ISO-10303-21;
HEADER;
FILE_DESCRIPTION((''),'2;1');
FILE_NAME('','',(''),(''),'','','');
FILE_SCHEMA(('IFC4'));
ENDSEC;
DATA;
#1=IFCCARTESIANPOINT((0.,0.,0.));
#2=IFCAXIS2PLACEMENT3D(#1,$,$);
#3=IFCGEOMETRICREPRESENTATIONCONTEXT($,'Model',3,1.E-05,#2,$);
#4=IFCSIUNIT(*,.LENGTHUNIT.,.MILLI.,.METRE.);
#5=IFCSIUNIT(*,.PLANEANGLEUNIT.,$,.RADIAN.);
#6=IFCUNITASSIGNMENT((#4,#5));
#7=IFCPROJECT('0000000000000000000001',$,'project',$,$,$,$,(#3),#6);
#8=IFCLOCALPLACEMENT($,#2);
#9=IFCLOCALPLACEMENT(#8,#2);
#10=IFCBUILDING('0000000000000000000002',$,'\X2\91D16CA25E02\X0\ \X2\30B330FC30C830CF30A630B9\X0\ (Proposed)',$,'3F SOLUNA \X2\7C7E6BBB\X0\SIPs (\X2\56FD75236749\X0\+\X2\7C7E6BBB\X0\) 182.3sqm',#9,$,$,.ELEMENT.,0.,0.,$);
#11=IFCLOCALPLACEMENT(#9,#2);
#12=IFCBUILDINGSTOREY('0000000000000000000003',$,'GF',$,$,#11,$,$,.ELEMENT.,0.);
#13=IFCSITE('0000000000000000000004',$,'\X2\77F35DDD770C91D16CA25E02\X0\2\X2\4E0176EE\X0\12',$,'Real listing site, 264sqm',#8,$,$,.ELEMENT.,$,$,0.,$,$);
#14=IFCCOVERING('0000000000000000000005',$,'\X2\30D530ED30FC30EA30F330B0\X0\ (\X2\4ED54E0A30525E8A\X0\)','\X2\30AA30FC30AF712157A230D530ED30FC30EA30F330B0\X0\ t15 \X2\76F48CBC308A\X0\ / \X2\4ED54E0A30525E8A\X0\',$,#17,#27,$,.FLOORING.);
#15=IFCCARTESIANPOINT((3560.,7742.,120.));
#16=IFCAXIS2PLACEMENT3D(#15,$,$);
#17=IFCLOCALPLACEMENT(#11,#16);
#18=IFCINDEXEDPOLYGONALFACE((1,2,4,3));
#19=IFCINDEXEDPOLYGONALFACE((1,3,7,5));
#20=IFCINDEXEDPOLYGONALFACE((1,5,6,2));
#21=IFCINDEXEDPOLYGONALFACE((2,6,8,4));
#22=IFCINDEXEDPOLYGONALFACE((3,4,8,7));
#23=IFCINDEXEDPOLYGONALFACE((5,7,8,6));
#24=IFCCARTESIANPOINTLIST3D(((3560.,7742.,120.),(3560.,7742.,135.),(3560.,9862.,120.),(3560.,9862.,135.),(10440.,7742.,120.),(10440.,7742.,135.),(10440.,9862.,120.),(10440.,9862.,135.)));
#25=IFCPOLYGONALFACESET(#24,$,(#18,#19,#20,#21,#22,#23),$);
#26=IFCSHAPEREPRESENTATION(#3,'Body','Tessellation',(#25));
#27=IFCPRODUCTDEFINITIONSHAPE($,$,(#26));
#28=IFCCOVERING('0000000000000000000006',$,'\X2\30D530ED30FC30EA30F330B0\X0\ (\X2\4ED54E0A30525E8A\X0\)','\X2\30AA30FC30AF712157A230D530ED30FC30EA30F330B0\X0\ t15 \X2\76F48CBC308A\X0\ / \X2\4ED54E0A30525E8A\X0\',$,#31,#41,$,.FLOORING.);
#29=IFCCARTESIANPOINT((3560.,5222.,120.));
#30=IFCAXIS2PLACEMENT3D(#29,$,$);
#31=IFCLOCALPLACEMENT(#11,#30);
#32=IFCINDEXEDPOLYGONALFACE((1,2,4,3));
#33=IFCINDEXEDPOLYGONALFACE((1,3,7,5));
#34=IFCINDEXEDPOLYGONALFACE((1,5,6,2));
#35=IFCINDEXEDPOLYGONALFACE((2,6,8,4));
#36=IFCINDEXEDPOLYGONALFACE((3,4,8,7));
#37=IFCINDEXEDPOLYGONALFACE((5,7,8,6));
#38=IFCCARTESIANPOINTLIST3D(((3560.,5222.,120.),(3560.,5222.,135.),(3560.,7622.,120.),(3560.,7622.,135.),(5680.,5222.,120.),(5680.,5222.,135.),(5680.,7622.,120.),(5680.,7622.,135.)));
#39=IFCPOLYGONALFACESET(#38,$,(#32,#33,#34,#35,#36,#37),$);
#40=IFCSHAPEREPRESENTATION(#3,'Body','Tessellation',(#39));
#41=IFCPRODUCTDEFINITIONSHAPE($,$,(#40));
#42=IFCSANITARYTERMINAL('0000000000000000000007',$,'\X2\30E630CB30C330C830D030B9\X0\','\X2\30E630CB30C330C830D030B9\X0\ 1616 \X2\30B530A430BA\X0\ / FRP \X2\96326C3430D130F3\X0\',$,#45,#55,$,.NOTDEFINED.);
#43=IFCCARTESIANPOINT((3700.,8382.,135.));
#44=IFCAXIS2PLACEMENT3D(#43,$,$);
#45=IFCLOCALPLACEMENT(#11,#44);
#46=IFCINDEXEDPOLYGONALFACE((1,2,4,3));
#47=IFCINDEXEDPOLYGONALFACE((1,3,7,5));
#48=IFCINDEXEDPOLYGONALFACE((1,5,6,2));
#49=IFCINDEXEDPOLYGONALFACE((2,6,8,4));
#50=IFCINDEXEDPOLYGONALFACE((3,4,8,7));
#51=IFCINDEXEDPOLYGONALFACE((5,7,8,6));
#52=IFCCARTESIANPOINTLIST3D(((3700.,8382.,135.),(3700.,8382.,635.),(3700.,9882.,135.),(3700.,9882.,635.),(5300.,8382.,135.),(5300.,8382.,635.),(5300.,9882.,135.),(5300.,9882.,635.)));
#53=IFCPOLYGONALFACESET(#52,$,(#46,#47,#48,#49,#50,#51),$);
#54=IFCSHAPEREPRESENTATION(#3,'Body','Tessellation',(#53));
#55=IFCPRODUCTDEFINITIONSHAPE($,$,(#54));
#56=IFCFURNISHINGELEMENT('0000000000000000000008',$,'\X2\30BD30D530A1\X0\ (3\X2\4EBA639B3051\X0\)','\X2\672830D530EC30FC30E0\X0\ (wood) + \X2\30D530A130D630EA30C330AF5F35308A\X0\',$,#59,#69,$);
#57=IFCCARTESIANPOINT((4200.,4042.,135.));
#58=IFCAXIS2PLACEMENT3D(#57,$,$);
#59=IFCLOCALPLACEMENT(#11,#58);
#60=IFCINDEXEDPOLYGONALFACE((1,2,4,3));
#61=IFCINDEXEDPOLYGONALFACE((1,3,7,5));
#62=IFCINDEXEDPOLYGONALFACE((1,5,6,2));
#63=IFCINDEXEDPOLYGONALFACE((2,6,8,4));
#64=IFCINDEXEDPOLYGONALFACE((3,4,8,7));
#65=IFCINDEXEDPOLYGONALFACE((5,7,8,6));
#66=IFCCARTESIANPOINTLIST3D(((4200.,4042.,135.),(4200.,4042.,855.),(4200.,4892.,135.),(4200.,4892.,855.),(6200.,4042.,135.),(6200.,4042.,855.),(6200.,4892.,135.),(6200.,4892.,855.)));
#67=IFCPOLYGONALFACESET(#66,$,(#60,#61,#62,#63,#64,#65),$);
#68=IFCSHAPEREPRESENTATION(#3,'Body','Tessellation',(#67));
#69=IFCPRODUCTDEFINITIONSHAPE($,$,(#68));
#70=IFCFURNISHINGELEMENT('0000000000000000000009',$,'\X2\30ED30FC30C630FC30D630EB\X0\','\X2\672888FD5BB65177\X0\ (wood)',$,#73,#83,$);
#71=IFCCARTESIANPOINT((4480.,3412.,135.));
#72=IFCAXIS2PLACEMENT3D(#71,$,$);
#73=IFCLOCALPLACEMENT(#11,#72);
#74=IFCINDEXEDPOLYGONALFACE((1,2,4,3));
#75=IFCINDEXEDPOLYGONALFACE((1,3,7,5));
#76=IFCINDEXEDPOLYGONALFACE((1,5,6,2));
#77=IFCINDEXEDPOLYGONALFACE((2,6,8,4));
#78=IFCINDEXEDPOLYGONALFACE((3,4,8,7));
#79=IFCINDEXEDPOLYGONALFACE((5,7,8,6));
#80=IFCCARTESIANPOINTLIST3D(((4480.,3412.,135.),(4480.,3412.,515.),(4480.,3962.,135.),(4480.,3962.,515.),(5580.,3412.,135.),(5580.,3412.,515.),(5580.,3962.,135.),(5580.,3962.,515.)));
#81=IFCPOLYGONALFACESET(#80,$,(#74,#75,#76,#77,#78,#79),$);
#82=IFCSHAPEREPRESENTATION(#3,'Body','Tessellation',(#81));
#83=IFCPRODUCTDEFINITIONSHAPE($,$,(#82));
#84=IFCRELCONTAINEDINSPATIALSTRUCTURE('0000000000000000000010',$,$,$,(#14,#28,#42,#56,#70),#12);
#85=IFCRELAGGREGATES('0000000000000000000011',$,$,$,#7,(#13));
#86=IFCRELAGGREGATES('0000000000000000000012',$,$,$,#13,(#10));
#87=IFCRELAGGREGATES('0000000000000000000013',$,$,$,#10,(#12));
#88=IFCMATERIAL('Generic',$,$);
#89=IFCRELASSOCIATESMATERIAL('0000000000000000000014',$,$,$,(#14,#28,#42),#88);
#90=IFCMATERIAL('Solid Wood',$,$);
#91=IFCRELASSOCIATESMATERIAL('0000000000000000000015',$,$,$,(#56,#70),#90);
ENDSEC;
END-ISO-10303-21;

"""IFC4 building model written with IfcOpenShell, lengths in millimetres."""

from ifc_helpers import new_model, si_unit, frame, frame_2d, origin, place, context, project, spatial, rectangle, extrude, material, element, save


model = new_model("IFC4")

# Units and contexts
model_context = context("Model", 3, precision=1e-05, world=origin())
ifc_project = project(units=[si_unit("LENGTHUNIT", "METRE", prefix="MILLI"), si_unit("PLANEANGLEUNIT", "RADIAN")], contexts=[model_context])

# Site, building, storey
site_placement = place(None, origin())
site = spatial("IfcSite", under=ifc_project, at=site_placement, Name="石川県金沢市2丁目12", ObjectType="Real listing site, 264sqm", CompositionType="ELEMENT", RefElevation=0.0)
building_placement = place(site_placement, origin())
building = spatial("IfcBuilding", under=site, at=building_placement, Name="金沢市 コートハウス (Proposed)", ObjectType="3F SOLUNA 籾殻SIPs (国産杉+籾殻) 182.3sqm", CompositionType="ELEMENT", ElevationOfRefHeight=0.0, ElevationOfTerrain=0.0)
storey_placement = place(building_placement, origin())
storey = spatial("IfcBuildingStorey", under=building, at=storey_placement, Name="GF", CompositionType="ELEMENT", Elevation=0.0)

# Shared definitions
ifc_material_1 = material(Name="Solid Wood")

# Coverings
ifc_material_2 = material(Name="Generic")
covering_1_placement = place(storey_placement, frame((3560.0, 7742.0, 120.0)))
element("IfcCovering", 1, at=covering_1_placement, inside=storey, material=ifc_material_2, Name="フローリング (仕上げ床)", Description="オーク無垢フローリング t15 直貼り / 仕上げ床", PredefinedType="FLOORING", context=model_context, shape_type="SweptSolid", body=[
    extrude(rectangle(XDim=6880.0, YDim=2120.0, at=frame_2d((3440.0, 1060.0))), frame((3560.0, 7742.0, 120.0)), (0.0, 0.0, 1.0), 15.0),
])
covering_2_placement = place(storey_placement, frame((3560.0, 5222.0, 120.0)))
element("IfcCovering", 2, at=covering_2_placement, inside=storey, material=ifc_material_2, Name="フローリング (仕上げ床)", Description="オーク無垢フローリング t15 直貼り / 仕上げ床", PredefinedType="FLOORING", context=model_context, shape_type="SweptSolid", body=[
    extrude(rectangle(XDim=2120.0, YDim=2400.0, at=frame_2d((1060.0, 1200.0))), frame((3560.0, 5222.0, 120.0)), (0.0, 0.0, 1.0), 15.0),
])

# Sanitary terminal
sanitary_terminal_placement = place(storey_placement, frame((3700.0, 8382.0, 135.0)))
element("IfcSanitaryTerminal", 3, at=sanitary_terminal_placement, inside=storey, material=ifc_material_2, Name="ユニットバス", Description="ユニットバス 1616 サイズ / FRP 防水パン", PredefinedType="NOTDEFINED", context=model_context, shape_type="SweptSolid", body=[
    extrude(rectangle(XDim=1600.0, YDim=1500.0, at=frame_2d((800.0, 750.0))), frame((3700.0, 8382.0, 135.0)), (0.0, 0.0, 1.0), 500.0),
])

# Furnishing elements
furnishing_1_placement = place(storey_placement, frame((4200.0, 4042.0, 135.0)))
element("IfcFurnishingElement", 4, at=furnishing_1_placement, inside=storey, material=ifc_material_1, Name="ソファ (3人掛け)", Description="木フレーム (wood) + ファブリック張り", context=model_context, shape_type="SweptSolid", body=[
    extrude(rectangle(XDim=2000.0, YDim=850.0, at=frame_2d((1000.0, 425.0))), frame((4200.0, 4042.0, 135.0)), (0.0, 0.0, 1.0), 720.0),
])
furnishing_2_placement = place(storey_placement, frame((4480.0, 3412.0, 135.0)))
element("IfcFurnishingElement", 5, at=furnishing_2_placement, inside=storey, material=ifc_material_1, Name="ローテーブル", Description="木製家具 (wood)", context=model_context, shape_type="SweptSolid", body=[
    extrude(rectangle(XDim=1100.0, YDim=550.0, at=frame_2d((550.0, 275.0))), frame((4480.0, 3412.0, 135.0)), (0.0, 0.0, 1.0), 380.0),
])

save(model, "model.ifc")
